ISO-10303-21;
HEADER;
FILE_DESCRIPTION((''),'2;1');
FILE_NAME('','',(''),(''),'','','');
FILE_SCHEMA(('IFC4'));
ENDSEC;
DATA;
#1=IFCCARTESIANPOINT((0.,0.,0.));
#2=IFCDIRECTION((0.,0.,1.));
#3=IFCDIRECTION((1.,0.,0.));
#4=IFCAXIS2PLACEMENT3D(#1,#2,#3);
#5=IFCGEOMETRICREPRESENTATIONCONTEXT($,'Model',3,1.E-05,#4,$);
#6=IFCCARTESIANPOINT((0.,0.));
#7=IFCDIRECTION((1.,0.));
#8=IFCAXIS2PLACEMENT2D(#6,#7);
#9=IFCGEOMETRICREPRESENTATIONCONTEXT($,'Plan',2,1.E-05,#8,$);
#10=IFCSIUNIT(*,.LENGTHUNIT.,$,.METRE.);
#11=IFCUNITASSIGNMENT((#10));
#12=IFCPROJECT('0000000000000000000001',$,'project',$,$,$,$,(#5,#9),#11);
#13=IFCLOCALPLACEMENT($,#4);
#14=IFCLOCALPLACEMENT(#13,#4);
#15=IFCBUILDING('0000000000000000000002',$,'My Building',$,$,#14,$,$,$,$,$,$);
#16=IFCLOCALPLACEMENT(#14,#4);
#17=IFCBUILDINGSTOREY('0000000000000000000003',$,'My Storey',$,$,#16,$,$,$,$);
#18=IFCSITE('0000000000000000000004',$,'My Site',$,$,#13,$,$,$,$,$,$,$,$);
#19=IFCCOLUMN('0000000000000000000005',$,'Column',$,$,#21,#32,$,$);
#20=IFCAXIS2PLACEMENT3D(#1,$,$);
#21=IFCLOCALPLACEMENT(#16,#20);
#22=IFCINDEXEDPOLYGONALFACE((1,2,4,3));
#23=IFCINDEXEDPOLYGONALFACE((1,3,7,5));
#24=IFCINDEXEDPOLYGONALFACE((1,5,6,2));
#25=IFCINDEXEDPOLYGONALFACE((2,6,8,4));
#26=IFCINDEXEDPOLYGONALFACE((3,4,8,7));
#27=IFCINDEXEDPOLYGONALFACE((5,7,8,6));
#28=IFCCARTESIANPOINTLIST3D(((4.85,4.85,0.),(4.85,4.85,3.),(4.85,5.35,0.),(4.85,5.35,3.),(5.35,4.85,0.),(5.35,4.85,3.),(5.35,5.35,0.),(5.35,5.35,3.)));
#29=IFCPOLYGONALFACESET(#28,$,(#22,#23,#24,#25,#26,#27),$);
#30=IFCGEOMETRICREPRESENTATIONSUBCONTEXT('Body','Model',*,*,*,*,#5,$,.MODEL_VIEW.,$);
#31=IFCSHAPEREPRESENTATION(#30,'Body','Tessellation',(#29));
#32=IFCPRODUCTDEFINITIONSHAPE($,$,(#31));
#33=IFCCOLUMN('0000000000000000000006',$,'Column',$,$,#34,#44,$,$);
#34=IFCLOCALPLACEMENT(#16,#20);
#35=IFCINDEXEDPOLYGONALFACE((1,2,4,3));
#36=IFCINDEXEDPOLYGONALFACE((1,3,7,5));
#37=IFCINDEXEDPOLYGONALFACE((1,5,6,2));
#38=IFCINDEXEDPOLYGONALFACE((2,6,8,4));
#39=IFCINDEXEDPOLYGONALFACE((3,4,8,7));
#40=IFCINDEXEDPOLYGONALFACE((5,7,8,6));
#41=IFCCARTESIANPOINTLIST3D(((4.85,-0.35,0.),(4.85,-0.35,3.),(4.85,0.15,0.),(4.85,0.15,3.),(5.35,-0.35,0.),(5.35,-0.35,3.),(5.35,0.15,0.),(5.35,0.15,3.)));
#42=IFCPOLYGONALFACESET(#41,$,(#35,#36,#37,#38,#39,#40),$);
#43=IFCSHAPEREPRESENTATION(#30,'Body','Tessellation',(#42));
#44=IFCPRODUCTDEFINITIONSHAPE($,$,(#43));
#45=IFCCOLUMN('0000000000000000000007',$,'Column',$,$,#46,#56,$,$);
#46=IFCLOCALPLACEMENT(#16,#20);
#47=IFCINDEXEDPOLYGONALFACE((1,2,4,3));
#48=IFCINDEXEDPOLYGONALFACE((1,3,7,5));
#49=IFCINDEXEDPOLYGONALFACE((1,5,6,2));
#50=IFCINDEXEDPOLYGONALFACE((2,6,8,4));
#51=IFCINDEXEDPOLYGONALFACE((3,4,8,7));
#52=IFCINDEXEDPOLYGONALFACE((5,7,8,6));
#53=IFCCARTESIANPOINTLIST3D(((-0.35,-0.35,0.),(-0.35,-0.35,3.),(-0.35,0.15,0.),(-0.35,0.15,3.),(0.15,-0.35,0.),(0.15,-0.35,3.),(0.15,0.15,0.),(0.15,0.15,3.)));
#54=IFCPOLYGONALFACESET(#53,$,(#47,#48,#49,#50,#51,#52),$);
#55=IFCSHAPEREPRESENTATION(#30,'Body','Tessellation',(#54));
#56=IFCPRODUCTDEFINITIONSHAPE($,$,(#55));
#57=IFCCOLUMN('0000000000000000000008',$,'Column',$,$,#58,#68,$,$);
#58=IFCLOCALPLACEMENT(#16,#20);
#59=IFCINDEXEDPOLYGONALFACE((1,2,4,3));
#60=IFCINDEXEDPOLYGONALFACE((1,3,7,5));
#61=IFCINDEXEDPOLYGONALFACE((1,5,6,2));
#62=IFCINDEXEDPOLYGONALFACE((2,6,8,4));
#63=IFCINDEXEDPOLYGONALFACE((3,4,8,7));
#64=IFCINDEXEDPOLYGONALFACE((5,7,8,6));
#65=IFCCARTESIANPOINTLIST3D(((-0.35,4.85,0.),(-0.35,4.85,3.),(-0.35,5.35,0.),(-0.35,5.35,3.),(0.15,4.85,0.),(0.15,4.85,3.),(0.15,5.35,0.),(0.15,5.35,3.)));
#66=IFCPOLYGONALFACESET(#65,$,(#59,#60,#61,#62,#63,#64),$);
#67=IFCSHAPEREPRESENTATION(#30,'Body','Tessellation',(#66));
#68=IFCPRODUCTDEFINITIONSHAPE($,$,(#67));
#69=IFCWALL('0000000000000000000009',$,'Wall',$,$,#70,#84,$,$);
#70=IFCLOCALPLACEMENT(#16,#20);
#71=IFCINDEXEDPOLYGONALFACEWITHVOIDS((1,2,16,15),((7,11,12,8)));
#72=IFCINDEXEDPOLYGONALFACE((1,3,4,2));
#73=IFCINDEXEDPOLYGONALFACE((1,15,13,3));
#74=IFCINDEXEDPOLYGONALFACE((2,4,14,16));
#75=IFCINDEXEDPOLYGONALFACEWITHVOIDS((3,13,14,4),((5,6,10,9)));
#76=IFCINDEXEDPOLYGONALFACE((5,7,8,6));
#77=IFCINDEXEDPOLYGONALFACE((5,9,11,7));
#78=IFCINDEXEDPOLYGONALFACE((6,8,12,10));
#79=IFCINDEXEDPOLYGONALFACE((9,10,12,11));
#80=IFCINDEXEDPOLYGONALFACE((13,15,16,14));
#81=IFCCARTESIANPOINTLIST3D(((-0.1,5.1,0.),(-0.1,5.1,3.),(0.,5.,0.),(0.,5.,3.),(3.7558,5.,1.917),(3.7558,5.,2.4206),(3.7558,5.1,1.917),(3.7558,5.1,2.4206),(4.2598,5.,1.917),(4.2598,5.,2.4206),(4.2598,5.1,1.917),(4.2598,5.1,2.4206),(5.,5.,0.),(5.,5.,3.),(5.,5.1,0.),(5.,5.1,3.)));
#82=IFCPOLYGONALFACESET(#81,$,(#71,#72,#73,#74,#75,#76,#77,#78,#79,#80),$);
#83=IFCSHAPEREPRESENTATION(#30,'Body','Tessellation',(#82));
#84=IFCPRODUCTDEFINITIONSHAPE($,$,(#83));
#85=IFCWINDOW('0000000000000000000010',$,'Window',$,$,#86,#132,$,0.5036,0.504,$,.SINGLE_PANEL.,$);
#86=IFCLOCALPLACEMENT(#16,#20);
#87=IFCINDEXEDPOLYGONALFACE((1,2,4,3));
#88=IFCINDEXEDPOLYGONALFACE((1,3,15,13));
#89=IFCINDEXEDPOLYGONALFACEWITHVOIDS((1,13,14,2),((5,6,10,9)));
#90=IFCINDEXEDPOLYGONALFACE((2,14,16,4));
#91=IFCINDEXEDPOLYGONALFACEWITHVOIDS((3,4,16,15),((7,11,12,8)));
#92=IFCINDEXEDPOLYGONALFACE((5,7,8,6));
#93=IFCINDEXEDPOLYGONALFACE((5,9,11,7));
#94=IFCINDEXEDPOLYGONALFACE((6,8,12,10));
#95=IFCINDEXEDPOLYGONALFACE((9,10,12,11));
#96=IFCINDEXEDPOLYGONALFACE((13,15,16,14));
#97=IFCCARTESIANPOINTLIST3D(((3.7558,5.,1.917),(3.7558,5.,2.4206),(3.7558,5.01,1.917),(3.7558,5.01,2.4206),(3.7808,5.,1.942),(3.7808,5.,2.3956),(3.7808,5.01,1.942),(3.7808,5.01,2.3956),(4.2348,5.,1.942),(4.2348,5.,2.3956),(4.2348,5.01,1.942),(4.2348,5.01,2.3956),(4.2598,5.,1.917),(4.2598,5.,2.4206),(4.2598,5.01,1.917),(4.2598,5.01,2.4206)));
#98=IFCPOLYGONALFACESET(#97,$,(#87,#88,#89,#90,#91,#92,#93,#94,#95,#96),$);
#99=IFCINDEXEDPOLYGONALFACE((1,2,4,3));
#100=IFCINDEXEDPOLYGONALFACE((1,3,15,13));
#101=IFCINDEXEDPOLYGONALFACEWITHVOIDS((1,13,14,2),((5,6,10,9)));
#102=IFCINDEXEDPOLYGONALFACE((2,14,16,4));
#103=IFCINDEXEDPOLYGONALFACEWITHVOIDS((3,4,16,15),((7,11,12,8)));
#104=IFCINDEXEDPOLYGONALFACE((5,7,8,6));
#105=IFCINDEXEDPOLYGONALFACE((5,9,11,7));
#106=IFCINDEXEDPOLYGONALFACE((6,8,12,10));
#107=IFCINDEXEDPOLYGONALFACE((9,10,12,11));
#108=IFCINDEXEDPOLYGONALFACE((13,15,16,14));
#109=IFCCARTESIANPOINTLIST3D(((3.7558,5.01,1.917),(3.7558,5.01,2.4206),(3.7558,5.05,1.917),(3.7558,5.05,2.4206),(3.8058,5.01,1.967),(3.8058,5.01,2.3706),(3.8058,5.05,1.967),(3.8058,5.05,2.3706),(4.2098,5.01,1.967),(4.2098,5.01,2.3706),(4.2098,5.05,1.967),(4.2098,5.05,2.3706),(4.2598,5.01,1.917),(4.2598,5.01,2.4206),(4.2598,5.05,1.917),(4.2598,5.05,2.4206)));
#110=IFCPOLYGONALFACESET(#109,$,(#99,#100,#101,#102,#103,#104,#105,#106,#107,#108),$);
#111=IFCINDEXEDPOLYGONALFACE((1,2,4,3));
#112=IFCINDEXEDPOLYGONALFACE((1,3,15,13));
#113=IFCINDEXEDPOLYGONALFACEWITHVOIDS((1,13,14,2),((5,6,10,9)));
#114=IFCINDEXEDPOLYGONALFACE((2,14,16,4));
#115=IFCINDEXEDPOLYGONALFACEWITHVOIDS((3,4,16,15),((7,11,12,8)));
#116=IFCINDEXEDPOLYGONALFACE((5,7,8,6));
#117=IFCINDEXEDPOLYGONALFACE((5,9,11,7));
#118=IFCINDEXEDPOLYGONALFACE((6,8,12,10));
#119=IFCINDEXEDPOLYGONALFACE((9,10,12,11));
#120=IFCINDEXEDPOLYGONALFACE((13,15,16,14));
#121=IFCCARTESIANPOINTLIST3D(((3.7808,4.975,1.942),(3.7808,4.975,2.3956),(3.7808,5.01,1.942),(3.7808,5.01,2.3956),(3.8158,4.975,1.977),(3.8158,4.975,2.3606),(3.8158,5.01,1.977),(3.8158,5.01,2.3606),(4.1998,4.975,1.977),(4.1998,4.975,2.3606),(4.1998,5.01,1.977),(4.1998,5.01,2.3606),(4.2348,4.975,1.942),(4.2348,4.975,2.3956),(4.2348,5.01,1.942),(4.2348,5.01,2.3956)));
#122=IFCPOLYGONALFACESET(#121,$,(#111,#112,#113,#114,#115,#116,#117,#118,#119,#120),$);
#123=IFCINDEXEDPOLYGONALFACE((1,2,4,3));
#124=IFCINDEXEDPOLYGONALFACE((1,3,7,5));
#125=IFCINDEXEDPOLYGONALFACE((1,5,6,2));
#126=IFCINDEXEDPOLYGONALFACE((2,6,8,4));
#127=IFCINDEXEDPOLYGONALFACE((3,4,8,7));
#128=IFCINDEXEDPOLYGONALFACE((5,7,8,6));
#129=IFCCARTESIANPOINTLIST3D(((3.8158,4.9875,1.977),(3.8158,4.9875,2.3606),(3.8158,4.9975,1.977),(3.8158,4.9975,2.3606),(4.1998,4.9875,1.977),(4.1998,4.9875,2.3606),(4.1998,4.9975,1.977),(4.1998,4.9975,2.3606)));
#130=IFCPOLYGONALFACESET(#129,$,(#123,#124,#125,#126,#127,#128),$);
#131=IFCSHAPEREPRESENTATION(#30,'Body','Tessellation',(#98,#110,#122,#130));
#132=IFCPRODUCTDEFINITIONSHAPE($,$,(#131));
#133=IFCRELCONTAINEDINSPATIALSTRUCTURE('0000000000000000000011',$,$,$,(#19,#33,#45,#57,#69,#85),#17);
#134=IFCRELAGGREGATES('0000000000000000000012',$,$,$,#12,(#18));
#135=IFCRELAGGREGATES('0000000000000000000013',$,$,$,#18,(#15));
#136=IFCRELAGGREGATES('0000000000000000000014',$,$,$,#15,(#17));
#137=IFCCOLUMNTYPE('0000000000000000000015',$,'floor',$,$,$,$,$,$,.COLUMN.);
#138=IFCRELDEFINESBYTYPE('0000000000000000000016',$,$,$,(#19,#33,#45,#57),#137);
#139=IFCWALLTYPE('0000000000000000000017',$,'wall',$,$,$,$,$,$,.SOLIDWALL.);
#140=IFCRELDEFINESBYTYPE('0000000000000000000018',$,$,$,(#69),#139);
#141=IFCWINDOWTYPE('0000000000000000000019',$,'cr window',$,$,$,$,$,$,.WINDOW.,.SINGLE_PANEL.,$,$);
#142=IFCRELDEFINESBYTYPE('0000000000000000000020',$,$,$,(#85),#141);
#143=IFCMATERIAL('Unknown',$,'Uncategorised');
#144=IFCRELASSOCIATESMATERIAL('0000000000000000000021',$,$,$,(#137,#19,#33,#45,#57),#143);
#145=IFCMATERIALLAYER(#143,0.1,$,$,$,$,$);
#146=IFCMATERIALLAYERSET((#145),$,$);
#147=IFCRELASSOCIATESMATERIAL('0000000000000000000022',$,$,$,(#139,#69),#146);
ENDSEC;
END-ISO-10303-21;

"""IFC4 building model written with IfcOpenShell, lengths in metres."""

from ifc_helpers import new_model, entity, si_unit, frame, origin_with_axes, origin_2d_with_axis, place, context, subcontext, project, spatial, line, indexed_curve, rectangle, outline, extrude, shape, source, transform, mapped, material, layer, layer_set, layer_usage, material_profile, profile_set, profile_usage, type_object, type_shapes, element, fill, save


model = new_model("IFC4")

# Units and contexts
model_context = context("Model", 3, precision=1e-05, world=origin_with_axes())
plan_context = context("Plan", 2, precision=1e-05, world=origin_2d_with_axis())
body_context_1 = subcontext(model_context, "Body", "Model", "MODEL_VIEW")
body_context_2 = subcontext(plan_context, "Body", "Plan", "PLAN_VIEW")
ifc_project = project(units=[si_unit("LENGTHUNIT", "METRE")], contexts=[model_context, plan_context])

# Site, building, storey
site_placement = place(None, origin_with_axes())
site = spatial("IfcSite", under=ifc_project, at=site_placement, Name="My Site")
building_placement = place(site_placement, origin_with_axes())
building = spatial("IfcBuilding", under=site, at=building_placement, Name="My Building")
storey_placement = place(building_placement, origin_with_axes())
storey = spatial("IfcBuildingStorey", under=building, at=storey_placement, Name="My Storey")

# Columns
ifc_material = material(Name="Unknown", Category="Uncategorised")
ifc_material_profile = material_profile(ifc_material, rectangle(XDim=0.5, YDim=0.5))
ifc_profile_set = profile_set([ifc_material_profile])
ifc_profile_usage_1 = profile_usage(ifc_profile_set, cardinal=5)
column_type = type_object("IfcColumnType", Name="floor", PredefinedType="COLUMN", material=ifc_profile_set)
column_1_placement = place(storey_placement, frame((5.1, 5.1, 0.0), z_axis=(0.0, 0.0, 1.0), x_axis=(1.0, 0.0, 0.0)))
element("IfcColumn", 1, at=column_1_placement, inside=storey, type_object=column_type, material=ifc_profile_usage_1, Name="Column", context=body_context_1, shape_type="SweptSolid", body=[
    extrude(rectangle(XDim=0.5, YDim=0.5), origin_with_axes(), (0.0, 0.0, 1.0), 3.0),
])
ifc_profile_usage_2 = profile_usage(ifc_profile_set, cardinal=5)
column_2_placement = place(storey_placement, frame((5.1, -0.1, 0.0), z_axis=(0.0, 0.0, 1.0), x_axis=(1.0, 0.0, 0.0)))
element("IfcColumn", 2, at=column_2_placement, inside=storey, type_object=column_type, material=ifc_profile_usage_2, Name="Column", context=body_context_1, shape_type="SweptSolid", body=[
    extrude(rectangle(XDim=0.5, YDim=0.5), origin_with_axes(), (0.0, 0.0, 1.0), 3.0),
])
ifc_profile_usage_3 = profile_usage(ifc_profile_set, cardinal=5)
column_3_placement = place(storey_placement, frame((-0.1, -0.1, 0.0), z_axis=(0.0, 0.0, 1.0), x_axis=(1.0, 0.0, 0.0)))
element("IfcColumn", 3, at=column_3_placement, inside=storey, type_object=column_type, material=ifc_profile_usage_3, Name="Column", context=body_context_1, shape_type="SweptSolid", body=[
    extrude(rectangle(XDim=0.5, YDim=0.5), origin_with_axes(), (0.0, 0.0, 1.0), 3.0),
])
ifc_profile_usage_4 = profile_usage(ifc_profile_set, cardinal=5)
column_4_placement = place(storey_placement, frame((-0.1, 5.1, 0.0), z_axis=(0.0, 0.0, 1.0), x_axis=(1.0, 0.0, 0.0)))
element("IfcColumn", 4, at=column_4_placement, inside=storey, type_object=column_type, material=ifc_profile_usage_4, Name="Column", context=body_context_1, shape_type="SweptSolid", body=[
    extrude(rectangle(XDim=0.5, YDim=0.5), origin_with_axes(), (0.0, 0.0, 1.0), 3.0),
])

# Shared definitions
ifc_layer_1 = layer(ifc_material, 0.1)
ifc_layer_set_1 = layer_set([ifc_layer_1])
wall_type = type_object("IfcWallType", Name="wall", PredefinedType="SOLIDWALL", material=ifc_layer_set_1)

# Wall, opening, window
ifc_layer_usage_1 = layer_usage(ifc_layer_set_1, "AXIS2", "POSITIVE", 0.0)
wall_1_placement = place(storey_placement, frame((0.0, 5.0, 0.0), z_axis=(0.0, 0.0, 1.0), x_axis=(1.0, 0.0, 0.0)))
wall_1 = element("IfcWall", 5, at=wall_1_placement, inside=storey, type_object=wall_type, material=ifc_layer_usage_1, Name="Wall", context=body_context_1, shape_type="SweptSolid", body=[
    extrude(outline(indexed_curve([(0.0, 0.0), (-0.1, 0.1), (5.0, 0.1), (5.0, 0.0)], segments=[line(1, 2, 3, 4, 1)])), origin_with_axes(), (0.0, 0.0, 1.0), 3.0),
])
shared_shape_1 = source(origin_with_axes(), body_context_1, "Body", "SweptSolid", [
    extrude(outline(indexed_curve([(0.0, 0.0), (0.504, 0.0), (0.504, 0.5036), (0.0, 0.5036)], segments=[line(1, 2, 3, 4, 1)])), frame((0.0, -0.6, 0.0), z_axis=(0.0, -1.0, 0.0), x_axis=(1.0, 0.0, 0.0)), (0.0, 0.0, -1.0), 1.2),
])
opening_1_placement = place(wall_1_placement, frame((4.2598, 0.1, 1.917), z_axis=(0.0, 0.0, 1.0), x_axis=(-1.0, 0.0, 0.0)))
opening_1 = element("IfcOpeningElement", 6, at=opening_1_placement, cuts=wall_1, PredefinedType="OPENING", context=body_context_1, shape_type="MappedRepresentation", body=[
    mapped(shared_shape_1, transform((0.0, 0.0, 0.0), x_axis=(1.0, 0.0, 0.0), y_axis=(0.0, 1.0, 0.0), z_axis=(0.0, 0.0, 1.0), scale=1.0)),
])
window_type_1 = type_object("IfcWindowType", Name="cr window", PartitioningType="SINGLE_PANEL", PredefinedType="WINDOW")
shared_shape_2 = source(origin_with_axes(), body_context_1, "Body", "SweptSolid", [
    extrude(outline(indexed_curve([(0.0, 0.0), (0.504, 0.0), (0.504, 0.5036), (0.0, 0.5036)], segments=[line(1, 2, 3, 4, 1)]), holes=[indexed_curve([(0.025, 0.025), (0.479, 0.025), (0.479, 0.4786), (0.025, 0.4786)], segments=[line(1, 2, 3, 4, 1)])]), frame((0.0, 0.09, 0.0), z_axis=(0.0, -1.0, 0.0), x_axis=(1.0, 0.0, 0.0)), (0.0, 0.0, -1.0), 0.01),
    extrude(outline(indexed_curve([(0.0, 0.0), (0.504, 0.0), (0.504, 0.5036), (0.0, 0.5036)], segments=[line(1, 2, 3, 4, 1)]), holes=[indexed_curve([(0.05, 0.05), (0.454, 0.05), (0.454, 0.4536), (0.05, 0.4536)], segments=[line(1, 2, 3, 4, 1)])]), frame((0.0, 0.05, 0.0), z_axis=(0.0, -1.0, 0.0), x_axis=(1.0, 0.0, 0.0)), (0.0, 0.0, -1.0), 0.04),
    extrude(outline(indexed_curve([(0.0, 0.0), (0.454, 0.0), (0.454, 0.4536), (0.0, 0.4536)], segments=[line(1, 2, 3, 4, 1)]), holes=[indexed_curve([(0.035, 0.035), (0.419, 0.035), (0.419, 0.4186), (0.035, 0.4186)], segments=[line(1, 2, 3, 4, 1)])]), frame((0.025, 0.09, 0.025), z_axis=(0.0, -1.0, 0.0), x_axis=(1.0, 0.0, 0.0)), (0.0, 0.0, -1.0), 0.035),
    extrude(outline(indexed_curve([(0.035, 0.035), (0.419, 0.035), (0.419, 0.4186), (0.035, 0.4186)], segments=[line(1, 2, 3, 4, 1)])), frame((0.025, 0.1025, 0.025), z_axis=(0.0, -1.0, 0.0), x_axis=(1.0, 0.0, 0.0)), (0.0, 0.0, -1.0), 0.01),
])
shared_shape_3 = source(origin_with_axes(), body_context_2, "Body", "Curve2D", [
    entity("IfcIndexedPolyCurve", entity("IfcCartesianPointList2D", [[0.05, 0.05], [0.454, 0.05]])),
    entity("IfcIndexedPolyCurve", entity("IfcCartesianPointList2D", [[0.0, 0.1], [0.025, 0.1], [0.025, 0.09], [0.05, 0.09], [0.05, 0.05], [0.0, 0.05]]), [entity("IfcLineIndex", [1, 2, 3, 4, 5, 6, 1])]),
    entity("IfcIndexedPolyCurve", entity("IfcCartesianPointList2D", [[0.504, 0.1], [0.479, 0.1], [0.479, 0.09], [0.454, 0.09], [0.454, 0.05], [0.504, 0.05]]), [entity("IfcLineIndex", [1, 2, 3, 4, 5, 6, 1])]),
    entity("IfcIndexedPolyCurve", entity("IfcCartesianPointList2D", [[0.025, 0.09], [0.06, 0.09], [0.06, 0.125], [0.025, 0.125]]), [entity("IfcLineIndex", [1, 2, 3, 4, 1])]),
    entity("IfcIndexedPolyCurve", entity("IfcCartesianPointList2D", [[0.479, 0.09], [0.444, 0.09], [0.444, 0.125], [0.479, 0.125]]), [entity("IfcLineIndex", [1, 2, 3, 4, 1])]),
    entity("IfcIndexedPolyCurve", entity("IfcCartesianPointList2D", [[0.06, 0.09], [0.444, 0.09]])),
    entity("IfcIndexedPolyCurve", entity("IfcCartesianPointList2D", [[0.06, 0.125], [0.444, 0.125]])),
    entity("IfcIndexedPolyCurve", entity("IfcCartesianPointList2D", [[0.06, 0.1075], [0.444, 0.1075]])),
])
type_shapes(window_type_1, [shared_shape_2, shared_shape_3])
window_1_placement = place(opening_1_placement, frame((0.0, 0.0, 0.0), z_axis=(0.0, 0.0, 1.0), x_axis=(1.0, 0.0, 0.0)))
window_1 = element("IfcWindow", 7, at=window_1_placement, inside=storey, type_object=window_type_1, Name="Window", OverallHeight=0.5036, OverallWidth=0.504, PartitioningType="SINGLE_PANEL", shapes=[
    shape(body_context_1, "Body", "MappedRepresentation", [mapped(shared_shape_2, transform((0.0, 0.0, 0.0), x_axis=(1.0, 0.0, 0.0), y_axis=(0.0, 1.0, 0.0), z_axis=(0.0, 0.0, 1.0), scale=1.0))]),
    shape(body_context_2, "Body", "MappedRepresentation", [mapped(shared_shape_3, transform((0.0, 0.0, 0.0), x_axis=(1.0, 0.0, 0.0), y_axis=(0.0, 1.0, 0.0), z_axis=(0.0, 0.0, 1.0), scale=1.0))]),
])
fill(opening_1, window_1)

save(model, "model.ifc")
